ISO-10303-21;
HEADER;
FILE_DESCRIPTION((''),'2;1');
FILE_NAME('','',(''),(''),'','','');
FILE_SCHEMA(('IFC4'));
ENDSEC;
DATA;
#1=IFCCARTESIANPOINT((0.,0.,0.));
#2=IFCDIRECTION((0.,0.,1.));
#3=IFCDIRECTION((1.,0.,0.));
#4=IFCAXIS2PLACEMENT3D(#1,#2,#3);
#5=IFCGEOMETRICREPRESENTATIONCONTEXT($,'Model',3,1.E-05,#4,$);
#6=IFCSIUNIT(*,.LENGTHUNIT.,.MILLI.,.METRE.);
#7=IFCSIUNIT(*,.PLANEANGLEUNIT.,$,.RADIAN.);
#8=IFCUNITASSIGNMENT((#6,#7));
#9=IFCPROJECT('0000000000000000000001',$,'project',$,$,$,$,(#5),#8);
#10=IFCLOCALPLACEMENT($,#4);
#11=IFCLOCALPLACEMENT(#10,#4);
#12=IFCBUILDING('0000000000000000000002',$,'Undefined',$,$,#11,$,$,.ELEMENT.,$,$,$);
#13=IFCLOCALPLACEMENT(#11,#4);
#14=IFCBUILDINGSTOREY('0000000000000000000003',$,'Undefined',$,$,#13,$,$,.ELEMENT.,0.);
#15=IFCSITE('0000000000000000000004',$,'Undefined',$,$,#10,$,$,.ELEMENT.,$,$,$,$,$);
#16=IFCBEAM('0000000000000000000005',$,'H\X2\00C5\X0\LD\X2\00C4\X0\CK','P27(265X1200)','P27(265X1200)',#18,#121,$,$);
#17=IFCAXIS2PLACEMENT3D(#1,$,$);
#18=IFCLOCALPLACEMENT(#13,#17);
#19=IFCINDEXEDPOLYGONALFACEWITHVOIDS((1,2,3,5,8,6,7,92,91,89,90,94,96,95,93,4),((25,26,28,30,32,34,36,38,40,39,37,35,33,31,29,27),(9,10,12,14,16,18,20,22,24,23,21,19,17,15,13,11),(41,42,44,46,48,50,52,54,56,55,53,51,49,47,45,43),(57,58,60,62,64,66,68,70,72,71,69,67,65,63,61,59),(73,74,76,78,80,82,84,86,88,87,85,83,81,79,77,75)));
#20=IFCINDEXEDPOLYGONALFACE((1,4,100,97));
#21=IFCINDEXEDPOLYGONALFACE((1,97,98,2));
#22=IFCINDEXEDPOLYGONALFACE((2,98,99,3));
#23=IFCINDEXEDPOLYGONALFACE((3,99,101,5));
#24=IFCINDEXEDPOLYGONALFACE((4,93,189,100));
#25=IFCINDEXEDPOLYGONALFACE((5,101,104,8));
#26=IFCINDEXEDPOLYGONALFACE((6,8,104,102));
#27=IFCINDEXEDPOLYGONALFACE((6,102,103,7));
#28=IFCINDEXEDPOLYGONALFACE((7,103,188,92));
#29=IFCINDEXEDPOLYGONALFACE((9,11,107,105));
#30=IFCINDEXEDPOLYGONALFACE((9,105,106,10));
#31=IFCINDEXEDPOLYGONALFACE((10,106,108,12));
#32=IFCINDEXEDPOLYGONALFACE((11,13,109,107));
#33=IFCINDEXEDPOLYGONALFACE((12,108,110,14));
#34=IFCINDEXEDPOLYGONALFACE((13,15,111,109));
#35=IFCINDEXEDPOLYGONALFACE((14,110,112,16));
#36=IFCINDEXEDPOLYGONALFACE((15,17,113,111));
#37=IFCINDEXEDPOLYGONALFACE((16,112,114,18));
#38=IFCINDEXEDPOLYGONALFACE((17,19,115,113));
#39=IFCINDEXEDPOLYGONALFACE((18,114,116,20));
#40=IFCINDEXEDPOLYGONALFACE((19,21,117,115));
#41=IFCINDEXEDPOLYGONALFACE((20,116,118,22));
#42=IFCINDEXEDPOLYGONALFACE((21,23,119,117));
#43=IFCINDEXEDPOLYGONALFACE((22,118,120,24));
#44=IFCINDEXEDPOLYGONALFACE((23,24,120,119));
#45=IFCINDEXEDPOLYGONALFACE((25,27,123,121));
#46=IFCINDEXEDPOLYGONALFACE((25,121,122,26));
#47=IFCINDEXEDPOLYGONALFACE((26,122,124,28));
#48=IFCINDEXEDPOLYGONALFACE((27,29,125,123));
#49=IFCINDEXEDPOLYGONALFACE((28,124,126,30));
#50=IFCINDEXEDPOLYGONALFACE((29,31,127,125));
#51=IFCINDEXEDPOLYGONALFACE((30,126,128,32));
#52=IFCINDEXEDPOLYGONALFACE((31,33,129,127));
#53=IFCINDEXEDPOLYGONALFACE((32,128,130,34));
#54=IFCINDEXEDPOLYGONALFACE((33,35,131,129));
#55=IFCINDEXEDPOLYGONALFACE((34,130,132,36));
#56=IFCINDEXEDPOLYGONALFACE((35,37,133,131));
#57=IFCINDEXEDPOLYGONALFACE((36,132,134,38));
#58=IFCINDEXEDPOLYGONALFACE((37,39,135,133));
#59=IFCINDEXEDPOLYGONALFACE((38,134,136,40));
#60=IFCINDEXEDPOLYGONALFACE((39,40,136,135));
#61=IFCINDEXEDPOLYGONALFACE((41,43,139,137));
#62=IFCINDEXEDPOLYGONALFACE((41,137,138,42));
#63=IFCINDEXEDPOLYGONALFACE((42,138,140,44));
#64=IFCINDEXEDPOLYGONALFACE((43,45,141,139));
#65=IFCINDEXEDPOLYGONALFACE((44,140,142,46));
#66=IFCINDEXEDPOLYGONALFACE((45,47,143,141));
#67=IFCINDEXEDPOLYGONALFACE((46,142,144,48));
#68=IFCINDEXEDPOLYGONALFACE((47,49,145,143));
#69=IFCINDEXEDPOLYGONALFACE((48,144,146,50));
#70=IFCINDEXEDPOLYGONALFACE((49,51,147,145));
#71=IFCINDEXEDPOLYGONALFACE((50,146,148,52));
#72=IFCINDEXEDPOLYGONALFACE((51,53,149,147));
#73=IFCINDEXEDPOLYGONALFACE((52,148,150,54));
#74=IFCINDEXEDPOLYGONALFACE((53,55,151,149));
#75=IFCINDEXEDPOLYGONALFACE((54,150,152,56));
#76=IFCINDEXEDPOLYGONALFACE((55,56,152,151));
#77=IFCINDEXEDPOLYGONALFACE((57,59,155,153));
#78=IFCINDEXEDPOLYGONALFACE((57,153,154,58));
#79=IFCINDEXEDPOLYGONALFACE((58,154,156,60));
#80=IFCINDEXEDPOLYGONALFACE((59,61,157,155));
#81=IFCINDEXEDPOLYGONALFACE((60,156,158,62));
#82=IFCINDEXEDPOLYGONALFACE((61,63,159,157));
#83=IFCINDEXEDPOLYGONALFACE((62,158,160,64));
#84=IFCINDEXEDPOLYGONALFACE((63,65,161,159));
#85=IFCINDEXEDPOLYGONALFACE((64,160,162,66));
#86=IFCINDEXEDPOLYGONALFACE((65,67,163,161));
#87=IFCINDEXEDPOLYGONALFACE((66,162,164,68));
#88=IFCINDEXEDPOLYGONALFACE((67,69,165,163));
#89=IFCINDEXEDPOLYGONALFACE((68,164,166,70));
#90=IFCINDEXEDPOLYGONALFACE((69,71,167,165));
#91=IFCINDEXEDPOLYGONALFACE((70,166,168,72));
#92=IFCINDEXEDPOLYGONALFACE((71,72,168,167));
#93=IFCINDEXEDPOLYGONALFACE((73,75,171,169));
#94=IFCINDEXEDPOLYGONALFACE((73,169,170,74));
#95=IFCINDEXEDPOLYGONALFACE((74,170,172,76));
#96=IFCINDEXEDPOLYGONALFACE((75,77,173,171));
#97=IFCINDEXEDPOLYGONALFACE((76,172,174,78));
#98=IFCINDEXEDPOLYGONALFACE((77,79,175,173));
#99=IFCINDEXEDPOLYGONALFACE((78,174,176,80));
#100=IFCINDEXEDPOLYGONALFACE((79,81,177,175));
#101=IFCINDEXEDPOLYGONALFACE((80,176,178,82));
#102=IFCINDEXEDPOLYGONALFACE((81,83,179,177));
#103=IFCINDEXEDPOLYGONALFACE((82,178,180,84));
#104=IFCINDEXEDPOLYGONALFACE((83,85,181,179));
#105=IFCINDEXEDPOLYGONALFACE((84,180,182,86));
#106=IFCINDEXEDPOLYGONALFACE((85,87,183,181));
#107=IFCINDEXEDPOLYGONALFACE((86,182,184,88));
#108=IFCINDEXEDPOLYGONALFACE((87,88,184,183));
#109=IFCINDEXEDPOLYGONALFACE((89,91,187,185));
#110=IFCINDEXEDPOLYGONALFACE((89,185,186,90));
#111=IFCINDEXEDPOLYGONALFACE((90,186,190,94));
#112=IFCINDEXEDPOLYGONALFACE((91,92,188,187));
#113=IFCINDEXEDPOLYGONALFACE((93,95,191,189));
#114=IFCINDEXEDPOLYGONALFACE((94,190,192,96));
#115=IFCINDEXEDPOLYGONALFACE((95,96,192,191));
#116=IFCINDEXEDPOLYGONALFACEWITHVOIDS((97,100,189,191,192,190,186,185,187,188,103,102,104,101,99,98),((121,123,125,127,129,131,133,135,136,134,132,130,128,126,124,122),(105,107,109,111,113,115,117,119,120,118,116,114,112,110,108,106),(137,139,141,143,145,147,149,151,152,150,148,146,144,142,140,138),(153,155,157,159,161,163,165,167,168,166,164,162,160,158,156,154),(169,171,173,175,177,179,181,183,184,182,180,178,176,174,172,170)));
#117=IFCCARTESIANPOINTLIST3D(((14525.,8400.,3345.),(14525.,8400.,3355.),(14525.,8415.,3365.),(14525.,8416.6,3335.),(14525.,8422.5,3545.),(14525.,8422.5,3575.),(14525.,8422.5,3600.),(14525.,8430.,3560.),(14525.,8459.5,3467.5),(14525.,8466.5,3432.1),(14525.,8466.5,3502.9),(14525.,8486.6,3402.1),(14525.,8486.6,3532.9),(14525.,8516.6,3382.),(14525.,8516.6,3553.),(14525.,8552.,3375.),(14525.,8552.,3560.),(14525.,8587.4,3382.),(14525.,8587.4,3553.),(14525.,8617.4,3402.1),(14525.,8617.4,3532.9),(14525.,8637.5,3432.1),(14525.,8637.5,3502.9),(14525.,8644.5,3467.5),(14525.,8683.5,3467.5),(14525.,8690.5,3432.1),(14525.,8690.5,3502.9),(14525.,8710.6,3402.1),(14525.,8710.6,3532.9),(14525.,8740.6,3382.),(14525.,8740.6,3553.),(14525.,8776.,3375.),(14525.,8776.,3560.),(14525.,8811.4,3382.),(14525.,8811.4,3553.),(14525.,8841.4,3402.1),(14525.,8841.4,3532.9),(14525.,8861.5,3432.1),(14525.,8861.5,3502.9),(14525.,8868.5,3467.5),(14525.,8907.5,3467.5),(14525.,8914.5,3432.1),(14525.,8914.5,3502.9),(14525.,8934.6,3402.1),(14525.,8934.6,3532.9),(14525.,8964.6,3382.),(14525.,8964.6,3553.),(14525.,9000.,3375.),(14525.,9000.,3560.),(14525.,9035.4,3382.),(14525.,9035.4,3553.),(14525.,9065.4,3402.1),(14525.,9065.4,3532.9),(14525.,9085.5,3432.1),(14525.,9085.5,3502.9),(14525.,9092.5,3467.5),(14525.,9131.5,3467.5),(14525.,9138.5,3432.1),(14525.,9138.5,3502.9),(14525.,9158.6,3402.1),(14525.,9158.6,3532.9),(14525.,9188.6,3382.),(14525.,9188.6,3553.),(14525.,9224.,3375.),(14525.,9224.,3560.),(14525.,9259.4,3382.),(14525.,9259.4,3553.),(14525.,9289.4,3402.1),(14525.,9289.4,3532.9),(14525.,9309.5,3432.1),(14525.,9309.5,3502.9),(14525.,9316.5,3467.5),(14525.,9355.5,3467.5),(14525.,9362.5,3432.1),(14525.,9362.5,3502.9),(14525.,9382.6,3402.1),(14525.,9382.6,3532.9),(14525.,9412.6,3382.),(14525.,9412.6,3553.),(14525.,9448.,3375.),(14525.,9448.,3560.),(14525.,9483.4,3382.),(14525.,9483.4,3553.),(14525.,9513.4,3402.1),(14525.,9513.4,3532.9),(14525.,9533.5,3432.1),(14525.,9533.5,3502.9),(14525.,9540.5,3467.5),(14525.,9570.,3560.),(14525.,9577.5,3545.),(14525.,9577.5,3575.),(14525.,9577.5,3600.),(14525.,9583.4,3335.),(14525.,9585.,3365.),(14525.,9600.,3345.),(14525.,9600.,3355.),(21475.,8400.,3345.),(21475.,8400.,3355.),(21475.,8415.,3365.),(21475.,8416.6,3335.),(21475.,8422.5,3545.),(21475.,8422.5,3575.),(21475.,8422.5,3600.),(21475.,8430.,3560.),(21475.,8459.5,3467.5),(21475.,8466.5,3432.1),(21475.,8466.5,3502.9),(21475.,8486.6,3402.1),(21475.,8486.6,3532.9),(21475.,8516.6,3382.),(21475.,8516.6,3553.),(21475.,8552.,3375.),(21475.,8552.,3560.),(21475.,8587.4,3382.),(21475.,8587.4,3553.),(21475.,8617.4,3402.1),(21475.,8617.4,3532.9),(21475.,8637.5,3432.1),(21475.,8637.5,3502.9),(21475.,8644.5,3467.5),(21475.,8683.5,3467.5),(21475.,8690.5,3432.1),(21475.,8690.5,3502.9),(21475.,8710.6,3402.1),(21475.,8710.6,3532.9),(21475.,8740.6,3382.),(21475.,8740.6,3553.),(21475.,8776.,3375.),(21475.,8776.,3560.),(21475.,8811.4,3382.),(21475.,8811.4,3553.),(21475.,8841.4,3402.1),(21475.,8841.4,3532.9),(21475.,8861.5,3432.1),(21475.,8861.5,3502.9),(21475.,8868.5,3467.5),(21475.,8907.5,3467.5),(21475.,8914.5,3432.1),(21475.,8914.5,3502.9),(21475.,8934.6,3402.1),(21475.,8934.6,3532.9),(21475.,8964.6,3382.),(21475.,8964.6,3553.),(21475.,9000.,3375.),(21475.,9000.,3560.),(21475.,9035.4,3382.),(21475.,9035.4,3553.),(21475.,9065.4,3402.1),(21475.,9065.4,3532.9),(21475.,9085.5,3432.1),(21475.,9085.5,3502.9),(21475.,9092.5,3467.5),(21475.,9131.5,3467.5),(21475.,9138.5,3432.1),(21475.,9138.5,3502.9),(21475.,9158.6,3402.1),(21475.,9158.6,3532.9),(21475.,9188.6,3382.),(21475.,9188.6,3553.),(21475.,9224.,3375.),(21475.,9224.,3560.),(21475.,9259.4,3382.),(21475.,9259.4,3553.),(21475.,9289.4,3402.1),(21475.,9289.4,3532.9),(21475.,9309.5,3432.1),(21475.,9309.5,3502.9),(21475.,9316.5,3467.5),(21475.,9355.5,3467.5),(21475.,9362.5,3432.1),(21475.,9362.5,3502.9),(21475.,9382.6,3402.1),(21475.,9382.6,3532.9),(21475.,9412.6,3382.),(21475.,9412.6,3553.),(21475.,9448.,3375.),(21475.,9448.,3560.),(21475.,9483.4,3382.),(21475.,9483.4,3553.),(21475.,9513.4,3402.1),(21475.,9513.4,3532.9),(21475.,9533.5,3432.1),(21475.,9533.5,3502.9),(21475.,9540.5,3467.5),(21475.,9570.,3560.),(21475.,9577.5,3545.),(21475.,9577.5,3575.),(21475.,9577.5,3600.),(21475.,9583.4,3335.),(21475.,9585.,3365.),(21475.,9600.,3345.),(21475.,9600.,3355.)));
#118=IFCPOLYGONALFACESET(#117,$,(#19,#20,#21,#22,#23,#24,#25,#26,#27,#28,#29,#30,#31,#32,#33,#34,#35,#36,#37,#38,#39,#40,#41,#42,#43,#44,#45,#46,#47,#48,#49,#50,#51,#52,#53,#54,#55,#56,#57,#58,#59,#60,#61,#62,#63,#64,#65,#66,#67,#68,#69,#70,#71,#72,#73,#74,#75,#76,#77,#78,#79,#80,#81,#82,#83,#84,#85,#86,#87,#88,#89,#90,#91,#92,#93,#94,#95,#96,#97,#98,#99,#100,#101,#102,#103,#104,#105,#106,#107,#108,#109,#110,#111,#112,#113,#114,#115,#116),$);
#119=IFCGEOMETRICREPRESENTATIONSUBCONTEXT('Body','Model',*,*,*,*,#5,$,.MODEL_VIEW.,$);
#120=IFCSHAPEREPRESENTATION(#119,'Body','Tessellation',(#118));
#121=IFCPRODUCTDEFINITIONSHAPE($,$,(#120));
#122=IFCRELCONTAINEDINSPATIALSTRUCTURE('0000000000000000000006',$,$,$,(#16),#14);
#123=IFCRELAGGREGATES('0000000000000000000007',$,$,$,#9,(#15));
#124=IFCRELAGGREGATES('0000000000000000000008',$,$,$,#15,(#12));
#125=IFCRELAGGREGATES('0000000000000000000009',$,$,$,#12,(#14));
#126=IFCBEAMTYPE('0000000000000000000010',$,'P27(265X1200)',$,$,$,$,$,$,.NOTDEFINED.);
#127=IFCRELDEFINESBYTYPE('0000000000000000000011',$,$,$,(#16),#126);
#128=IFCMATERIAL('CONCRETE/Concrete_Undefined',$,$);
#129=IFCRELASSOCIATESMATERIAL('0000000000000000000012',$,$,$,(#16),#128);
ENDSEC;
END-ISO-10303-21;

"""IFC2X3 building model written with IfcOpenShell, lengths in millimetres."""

from ifc_helpers import new_model, si_unit, frame, origin_with_axes, place, context, subcontext, project, spatial, polyline, outline, extrude, material, type_object, element, save


model = new_model("IFC2X3")

# Units and contexts
model_context = context("Model", 3, precision=1e-05, world=origin_with_axes())
body_context = subcontext(model_context, "Body", "Model", "MODEL_VIEW")
ifc_project = project(units=[si_unit("LENGTHUNIT", "METRE", prefix="MILLI"), si_unit("PLANEANGLEUNIT", "RADIAN")], contexts=[model_context])

# Site, building, storey
site_placement = place(None, origin_with_axes())
site = spatial("IfcSite", under=ifc_project, at=site_placement, Name="Undefined", CompositionType="ELEMENT")
building_placement = place(site_placement, origin_with_axes())
building = spatial("IfcBuilding", under=site, at=building_placement, Name="Undefined", CompositionType="ELEMENT")
storey_placement = place(building_placement, origin_with_axes())
storey = spatial("IfcBuildingStorey", under=building, at=storey_placement, Name="Undefined", CompositionType="ELEMENT", Elevation=0.0)

# Beam
ifc_material_1 = material(Name="CONCRETE/Concrete_Undefined")
beam_type_1 = type_object("IfcBeamType", Name="P27(265X1200)", PredefinedType="NOTDEFINED")
beam_1_placement = place(storey_placement, frame((14525.0, 9000.0, 3467.5), z_axis=(0.0, 0.0, 1.0), x_axis=(1.0, 0.0, 0.0)))
element("IfcBeam", 1, at=beam_1_placement, inside=storey, type_object=beam_type_1, material=ifc_material_1, Name="HÅLDÄCK", Description="P27(265X1200)", ObjectType="P27(265X1200)", context=body_context, shape_type="SweptSolid", body=[
    extrude(outline(polyline([(-583.4, -132.5), (-600.0, -122.5), (-600.0, -112.5), (-585.0, -102.5), (-577.5, 77.5), (-570.0, 92.5), (-577.5, 107.5), (-577.5, 132.5), (577.5, 132.5), (577.5, 107.5), (570.0, 92.5), (577.5, 77.5), (585.0, -102.5), (600.0, -112.5), (600.0, -122.5), (583.4, -132.5), (-583.4, -132.5)]), holes=[polyline([(-513.4, 65.4), (-533.5, 35.4), (-540.5, 0.0), (-533.5, -35.4), (-513.4, -65.4), (-483.4, -85.5), (-448.0, -92.5), (-412.6, -85.5), (-382.6, -65.4), (-362.5, -35.4), (-355.5, 0.0), (-362.5, 35.4), (-382.6, 65.4), (-412.6, 85.5), (-448.0, 92.5), (-483.4, 85.5), (-513.4, 65.4)]), polyline([(-289.4, 65.4), (-309.5, 35.4), (-316.5, 0.0), (-309.5, -35.4), (-289.4, -65.4), (-259.4, -85.5), (-224.0, -92.5), (-188.6, -85.5), (-158.6, -65.4), (-138.5, -35.4), (-131.5, 0.0), (-138.5, 35.4), (-158.6, 65.4), (-188.6, 85.5), (-224.0, 92.5), (-259.4, 85.5), (-289.4, 65.4)]), polyline([(-65.4, 65.4), (-85.5, 35.4), (-92.5, 0.0), (-85.5, -35.4), (-65.4, -65.4), (-35.4, -85.5), (0.0, -92.5), (35.4, -85.5), (65.4, -65.4), (85.5, -35.4), (92.5, 0.0), (85.5, 35.4), (65.4, 65.4), (35.4, 85.5), (0.0, 92.5), (-35.4, 85.5), (-65.4, 65.4)]), polyline([(158.6, 65.4), (138.5, 35.4), (131.5, 0.0), (138.5, -35.4), (158.6, -65.4), (188.6, -85.5), (224.0, -92.5), (259.4, -85.5), (289.4, -65.4), (309.5, -35.4), (316.5, 0.0), (309.5, 35.4), (289.4, 65.4), (259.4, 85.5), (224.0, 92.5), (188.6, 85.5), (158.6, 65.4)]), polyline([(382.6, 65.4), (362.5, 35.4), (355.5, 0.0), (362.5, -35.4), (382.6, -65.4), (412.6, -85.5), (448.0, -92.5), (483.4, -85.5), (513.4, -65.4), (533.5, -35.4), (540.5, 0.0), (533.5, 35.4), (513.4, 65.4), (483.4, 85.5), (448.0, 92.5), (412.6, 85.5), (382.6, 65.4)])]), frame((6950.0, 0.0, 0.0), z_axis=(-1.0, 0.0, 0.0), x_axis=(0.0, -1.0, 0.0)), (0.0, 0.0, 1.0), 6950.0),
])

save(model, "model.ifc")
